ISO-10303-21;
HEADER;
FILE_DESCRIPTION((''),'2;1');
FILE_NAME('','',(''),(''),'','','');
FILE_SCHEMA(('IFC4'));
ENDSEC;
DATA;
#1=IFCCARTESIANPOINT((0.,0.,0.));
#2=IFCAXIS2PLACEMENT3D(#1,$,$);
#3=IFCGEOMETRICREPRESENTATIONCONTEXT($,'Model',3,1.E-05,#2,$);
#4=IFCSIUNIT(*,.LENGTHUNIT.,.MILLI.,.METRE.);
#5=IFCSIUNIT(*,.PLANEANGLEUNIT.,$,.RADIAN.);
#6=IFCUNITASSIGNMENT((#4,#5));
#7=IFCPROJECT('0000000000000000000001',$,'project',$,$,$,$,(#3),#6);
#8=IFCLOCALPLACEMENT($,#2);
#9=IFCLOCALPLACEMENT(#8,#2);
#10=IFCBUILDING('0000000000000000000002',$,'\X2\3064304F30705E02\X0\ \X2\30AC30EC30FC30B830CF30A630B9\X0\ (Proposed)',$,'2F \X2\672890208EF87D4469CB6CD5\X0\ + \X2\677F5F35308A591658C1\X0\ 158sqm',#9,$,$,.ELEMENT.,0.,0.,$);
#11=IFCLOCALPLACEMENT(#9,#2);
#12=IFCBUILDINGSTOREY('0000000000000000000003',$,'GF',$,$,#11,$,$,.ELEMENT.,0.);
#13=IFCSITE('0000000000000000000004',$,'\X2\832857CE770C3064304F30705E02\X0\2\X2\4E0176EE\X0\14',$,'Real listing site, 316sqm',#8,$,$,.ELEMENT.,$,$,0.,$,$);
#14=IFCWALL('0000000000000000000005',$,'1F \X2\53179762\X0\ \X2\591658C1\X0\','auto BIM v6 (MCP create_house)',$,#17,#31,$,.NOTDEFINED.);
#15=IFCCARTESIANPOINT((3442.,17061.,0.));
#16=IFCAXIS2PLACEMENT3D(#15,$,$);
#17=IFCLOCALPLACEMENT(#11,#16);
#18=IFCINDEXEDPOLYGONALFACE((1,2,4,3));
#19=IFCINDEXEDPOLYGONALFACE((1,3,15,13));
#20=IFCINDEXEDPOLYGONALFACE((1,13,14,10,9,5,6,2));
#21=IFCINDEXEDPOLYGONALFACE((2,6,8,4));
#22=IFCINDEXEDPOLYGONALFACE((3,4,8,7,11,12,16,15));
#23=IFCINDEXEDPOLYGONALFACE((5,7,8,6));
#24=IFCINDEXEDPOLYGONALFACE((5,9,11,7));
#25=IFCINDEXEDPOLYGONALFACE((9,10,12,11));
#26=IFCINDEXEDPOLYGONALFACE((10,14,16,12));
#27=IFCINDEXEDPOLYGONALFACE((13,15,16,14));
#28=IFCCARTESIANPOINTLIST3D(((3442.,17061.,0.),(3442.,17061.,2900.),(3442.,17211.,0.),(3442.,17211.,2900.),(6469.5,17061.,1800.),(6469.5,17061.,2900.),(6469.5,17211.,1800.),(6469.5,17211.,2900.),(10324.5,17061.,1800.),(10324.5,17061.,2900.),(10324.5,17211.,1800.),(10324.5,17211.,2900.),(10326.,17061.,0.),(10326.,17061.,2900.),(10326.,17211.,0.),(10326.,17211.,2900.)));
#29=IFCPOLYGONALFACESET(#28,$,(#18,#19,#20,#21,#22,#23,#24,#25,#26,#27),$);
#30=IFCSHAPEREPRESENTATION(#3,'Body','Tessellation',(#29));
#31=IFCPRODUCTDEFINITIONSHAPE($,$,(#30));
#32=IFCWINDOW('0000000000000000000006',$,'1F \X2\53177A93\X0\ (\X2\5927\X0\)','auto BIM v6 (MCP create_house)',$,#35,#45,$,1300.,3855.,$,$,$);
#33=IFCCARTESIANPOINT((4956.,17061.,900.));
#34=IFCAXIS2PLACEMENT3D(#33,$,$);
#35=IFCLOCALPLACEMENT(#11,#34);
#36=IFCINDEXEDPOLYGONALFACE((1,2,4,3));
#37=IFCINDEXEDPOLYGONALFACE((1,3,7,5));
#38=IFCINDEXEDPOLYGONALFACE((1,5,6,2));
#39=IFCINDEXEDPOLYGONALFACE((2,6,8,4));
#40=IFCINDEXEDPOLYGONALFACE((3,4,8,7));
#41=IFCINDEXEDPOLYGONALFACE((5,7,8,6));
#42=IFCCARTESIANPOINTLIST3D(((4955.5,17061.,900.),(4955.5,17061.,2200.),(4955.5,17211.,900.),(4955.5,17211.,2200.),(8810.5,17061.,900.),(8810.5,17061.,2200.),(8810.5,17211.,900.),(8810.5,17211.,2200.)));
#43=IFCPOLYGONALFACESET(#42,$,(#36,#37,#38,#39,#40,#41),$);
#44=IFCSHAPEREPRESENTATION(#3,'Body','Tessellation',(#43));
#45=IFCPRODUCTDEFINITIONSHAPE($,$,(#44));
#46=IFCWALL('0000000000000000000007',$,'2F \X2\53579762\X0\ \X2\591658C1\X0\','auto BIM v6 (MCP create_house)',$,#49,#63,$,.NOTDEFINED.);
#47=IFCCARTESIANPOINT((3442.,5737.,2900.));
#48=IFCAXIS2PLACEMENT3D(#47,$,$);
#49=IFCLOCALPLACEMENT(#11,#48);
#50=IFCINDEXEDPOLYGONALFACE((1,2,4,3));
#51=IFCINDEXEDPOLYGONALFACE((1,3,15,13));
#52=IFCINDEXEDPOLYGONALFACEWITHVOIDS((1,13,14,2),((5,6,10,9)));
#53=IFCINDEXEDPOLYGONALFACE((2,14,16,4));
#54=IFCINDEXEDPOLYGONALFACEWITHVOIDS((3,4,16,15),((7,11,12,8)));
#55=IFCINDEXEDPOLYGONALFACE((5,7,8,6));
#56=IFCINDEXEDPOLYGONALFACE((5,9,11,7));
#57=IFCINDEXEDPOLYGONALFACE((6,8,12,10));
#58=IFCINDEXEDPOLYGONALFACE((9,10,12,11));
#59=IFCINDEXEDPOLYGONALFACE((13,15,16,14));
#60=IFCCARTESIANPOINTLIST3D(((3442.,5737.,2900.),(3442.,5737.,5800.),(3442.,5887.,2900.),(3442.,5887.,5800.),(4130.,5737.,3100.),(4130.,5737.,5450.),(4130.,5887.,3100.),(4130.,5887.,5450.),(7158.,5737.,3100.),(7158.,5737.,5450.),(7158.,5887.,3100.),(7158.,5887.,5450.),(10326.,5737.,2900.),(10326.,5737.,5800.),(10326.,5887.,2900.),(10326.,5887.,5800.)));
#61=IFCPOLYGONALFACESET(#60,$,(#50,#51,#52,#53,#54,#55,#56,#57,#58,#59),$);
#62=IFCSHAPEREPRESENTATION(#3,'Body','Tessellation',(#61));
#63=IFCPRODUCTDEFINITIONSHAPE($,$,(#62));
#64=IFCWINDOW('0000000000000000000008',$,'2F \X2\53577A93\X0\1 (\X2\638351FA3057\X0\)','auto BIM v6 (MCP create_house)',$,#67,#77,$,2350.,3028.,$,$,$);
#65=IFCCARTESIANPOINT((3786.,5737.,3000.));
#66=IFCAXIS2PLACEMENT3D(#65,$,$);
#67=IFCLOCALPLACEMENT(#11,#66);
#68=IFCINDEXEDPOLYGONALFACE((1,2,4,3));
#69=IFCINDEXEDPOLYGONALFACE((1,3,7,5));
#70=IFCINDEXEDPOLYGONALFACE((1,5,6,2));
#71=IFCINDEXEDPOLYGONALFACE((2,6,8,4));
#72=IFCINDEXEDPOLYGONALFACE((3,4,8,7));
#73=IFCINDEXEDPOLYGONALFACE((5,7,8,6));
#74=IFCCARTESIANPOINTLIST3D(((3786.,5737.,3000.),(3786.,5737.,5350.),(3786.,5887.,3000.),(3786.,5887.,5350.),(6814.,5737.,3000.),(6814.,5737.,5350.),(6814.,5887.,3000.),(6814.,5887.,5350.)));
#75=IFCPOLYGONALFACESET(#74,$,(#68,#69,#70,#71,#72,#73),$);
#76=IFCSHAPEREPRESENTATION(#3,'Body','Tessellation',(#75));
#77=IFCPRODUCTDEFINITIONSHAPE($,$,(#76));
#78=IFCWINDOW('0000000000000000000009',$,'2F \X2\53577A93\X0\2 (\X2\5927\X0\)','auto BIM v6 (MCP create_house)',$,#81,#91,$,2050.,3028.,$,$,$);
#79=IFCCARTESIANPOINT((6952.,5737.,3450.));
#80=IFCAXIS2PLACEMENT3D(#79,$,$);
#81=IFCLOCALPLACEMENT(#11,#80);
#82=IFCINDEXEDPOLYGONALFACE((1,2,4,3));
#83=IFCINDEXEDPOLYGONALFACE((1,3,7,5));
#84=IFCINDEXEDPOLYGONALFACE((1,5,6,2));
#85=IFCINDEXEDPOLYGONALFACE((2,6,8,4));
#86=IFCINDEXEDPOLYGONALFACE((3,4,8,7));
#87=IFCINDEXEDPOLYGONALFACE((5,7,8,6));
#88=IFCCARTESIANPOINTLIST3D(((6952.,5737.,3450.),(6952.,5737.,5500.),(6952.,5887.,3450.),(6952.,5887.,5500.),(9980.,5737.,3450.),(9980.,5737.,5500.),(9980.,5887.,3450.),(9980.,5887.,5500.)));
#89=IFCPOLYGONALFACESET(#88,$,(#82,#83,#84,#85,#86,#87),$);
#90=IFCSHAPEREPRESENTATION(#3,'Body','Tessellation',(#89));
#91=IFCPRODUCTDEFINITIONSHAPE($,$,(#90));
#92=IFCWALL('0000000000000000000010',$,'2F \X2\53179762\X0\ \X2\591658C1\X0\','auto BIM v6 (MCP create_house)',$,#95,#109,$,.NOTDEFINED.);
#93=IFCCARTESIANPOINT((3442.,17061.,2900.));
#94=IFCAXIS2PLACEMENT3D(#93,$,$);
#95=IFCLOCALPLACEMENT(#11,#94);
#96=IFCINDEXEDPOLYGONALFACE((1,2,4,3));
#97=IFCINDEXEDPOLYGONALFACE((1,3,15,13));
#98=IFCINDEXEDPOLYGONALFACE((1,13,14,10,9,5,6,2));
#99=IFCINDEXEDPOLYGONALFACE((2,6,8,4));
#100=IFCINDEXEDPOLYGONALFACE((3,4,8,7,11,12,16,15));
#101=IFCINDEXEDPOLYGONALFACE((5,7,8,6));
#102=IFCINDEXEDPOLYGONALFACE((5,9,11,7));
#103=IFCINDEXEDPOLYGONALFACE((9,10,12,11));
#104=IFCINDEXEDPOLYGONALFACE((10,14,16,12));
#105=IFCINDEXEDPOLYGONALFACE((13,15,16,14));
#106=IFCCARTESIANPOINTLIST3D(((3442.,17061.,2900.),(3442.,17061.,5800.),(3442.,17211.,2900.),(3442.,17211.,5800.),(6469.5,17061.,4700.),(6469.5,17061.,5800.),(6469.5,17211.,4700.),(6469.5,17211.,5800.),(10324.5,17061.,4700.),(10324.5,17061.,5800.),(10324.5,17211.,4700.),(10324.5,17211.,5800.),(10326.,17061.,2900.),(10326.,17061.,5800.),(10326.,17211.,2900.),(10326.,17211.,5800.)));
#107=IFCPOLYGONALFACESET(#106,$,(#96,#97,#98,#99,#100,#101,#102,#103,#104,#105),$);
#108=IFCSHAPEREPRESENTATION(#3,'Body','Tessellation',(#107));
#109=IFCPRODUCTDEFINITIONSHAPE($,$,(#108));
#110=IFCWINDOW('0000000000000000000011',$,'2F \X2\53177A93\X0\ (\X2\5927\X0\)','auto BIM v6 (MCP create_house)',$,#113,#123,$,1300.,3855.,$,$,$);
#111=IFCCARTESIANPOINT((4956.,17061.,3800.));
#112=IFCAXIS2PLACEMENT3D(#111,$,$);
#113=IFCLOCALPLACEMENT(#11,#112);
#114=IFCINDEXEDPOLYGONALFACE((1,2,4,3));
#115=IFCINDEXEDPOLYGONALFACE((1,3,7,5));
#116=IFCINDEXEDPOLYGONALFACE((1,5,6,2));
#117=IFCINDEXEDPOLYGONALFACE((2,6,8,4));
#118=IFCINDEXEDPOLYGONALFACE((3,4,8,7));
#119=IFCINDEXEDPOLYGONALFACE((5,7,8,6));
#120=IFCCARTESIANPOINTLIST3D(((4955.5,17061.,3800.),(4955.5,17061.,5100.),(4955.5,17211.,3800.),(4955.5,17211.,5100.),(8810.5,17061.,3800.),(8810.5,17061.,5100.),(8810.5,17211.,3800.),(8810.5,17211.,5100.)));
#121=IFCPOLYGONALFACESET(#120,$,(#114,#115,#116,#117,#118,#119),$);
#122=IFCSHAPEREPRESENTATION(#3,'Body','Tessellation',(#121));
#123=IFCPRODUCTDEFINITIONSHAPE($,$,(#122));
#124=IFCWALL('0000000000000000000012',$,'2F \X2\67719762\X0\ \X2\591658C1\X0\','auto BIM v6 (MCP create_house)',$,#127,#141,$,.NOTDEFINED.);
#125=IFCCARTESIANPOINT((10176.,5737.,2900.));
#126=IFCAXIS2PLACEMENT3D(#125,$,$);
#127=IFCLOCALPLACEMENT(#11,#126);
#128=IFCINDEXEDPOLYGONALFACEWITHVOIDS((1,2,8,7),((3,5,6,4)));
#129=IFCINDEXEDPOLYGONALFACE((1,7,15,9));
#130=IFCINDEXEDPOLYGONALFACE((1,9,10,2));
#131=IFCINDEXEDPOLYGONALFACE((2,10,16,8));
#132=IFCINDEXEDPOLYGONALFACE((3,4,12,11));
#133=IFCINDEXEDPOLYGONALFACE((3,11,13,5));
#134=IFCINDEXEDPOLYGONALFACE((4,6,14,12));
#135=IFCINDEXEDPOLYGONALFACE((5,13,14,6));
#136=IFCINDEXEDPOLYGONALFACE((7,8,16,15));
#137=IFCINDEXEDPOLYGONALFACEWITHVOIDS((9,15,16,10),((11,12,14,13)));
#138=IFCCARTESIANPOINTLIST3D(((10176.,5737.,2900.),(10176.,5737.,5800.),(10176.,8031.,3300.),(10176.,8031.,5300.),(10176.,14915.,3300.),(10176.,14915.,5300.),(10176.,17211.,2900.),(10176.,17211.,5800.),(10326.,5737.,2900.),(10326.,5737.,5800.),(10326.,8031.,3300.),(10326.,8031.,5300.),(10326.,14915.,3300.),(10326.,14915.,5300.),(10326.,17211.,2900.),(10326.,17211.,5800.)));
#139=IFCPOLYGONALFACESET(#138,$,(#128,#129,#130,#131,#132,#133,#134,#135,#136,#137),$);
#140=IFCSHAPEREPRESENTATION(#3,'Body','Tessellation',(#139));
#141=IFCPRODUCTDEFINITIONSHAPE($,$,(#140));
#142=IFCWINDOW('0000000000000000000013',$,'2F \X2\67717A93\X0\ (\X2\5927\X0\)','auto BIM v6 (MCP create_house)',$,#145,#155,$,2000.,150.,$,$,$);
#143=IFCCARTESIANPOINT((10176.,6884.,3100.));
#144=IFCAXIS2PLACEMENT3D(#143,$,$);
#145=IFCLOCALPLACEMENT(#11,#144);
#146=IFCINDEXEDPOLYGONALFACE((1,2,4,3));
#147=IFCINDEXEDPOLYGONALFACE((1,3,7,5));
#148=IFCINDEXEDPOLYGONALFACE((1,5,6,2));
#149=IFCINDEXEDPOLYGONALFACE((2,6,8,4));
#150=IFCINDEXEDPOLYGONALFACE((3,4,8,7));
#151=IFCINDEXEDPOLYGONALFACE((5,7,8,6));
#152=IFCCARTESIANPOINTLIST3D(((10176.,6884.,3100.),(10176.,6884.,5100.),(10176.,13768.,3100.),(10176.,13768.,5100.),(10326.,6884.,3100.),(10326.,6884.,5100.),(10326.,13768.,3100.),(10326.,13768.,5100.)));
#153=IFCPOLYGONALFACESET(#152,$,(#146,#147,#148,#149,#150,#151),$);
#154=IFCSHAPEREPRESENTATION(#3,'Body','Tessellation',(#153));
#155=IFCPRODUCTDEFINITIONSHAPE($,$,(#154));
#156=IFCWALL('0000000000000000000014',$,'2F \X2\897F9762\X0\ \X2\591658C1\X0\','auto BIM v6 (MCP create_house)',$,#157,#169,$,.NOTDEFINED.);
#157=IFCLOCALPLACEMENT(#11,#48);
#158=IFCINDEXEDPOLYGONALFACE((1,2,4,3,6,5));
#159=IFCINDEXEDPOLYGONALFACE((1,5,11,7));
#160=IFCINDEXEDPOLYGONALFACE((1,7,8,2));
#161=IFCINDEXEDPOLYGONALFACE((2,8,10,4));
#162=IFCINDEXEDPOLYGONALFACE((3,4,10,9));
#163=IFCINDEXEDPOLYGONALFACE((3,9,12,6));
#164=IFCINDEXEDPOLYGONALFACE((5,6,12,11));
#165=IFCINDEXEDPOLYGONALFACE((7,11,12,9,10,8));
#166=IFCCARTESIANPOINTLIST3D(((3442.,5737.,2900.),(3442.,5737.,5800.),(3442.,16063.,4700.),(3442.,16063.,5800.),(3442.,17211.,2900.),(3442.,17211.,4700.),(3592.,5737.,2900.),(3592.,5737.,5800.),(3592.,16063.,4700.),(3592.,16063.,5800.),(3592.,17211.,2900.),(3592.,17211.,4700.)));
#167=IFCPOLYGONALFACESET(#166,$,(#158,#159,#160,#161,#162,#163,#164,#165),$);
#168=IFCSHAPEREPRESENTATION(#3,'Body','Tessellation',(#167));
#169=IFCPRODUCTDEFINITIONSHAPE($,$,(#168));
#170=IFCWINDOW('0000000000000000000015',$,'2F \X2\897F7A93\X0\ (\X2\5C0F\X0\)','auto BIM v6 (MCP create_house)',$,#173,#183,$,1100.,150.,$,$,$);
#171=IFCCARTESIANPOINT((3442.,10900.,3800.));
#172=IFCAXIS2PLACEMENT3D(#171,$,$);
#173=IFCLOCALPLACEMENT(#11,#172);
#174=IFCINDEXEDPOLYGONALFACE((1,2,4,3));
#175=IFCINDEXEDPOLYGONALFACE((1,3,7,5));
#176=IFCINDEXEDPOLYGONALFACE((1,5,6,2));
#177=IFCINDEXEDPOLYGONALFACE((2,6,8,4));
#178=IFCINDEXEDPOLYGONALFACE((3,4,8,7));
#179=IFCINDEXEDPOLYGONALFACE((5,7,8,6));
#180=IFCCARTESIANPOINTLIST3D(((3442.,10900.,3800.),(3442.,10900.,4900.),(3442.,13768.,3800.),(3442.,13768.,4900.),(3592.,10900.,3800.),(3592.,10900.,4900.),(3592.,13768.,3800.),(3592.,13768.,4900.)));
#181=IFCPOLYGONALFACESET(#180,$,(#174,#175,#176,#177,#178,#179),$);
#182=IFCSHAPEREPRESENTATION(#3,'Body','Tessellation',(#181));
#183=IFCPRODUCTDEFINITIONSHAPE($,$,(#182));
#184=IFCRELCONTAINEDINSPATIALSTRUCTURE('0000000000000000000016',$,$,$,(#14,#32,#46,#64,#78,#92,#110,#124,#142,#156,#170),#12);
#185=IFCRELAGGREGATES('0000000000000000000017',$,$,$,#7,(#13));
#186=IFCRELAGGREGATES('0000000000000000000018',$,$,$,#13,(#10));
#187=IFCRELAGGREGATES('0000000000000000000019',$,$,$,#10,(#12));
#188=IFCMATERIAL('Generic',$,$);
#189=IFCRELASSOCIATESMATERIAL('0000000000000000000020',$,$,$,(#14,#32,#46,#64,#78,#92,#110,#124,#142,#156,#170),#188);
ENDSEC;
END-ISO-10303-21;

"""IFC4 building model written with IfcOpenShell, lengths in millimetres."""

from ifc_helpers import new_model, si_unit, frame, frame_2d, origin, place, context, project, spatial, rectangle, extrude, material, element, fill, save


model = new_model("IFC4")

# Units and contexts
model_context = context("Model", 3, precision=1e-05, world=origin())
ifc_project = project(units=[si_unit("LENGTHUNIT", "METRE", prefix="MILLI"), si_unit("PLANEANGLEUNIT", "RADIAN")], contexts=[model_context])

# Site, building, storey
site_placement = place(None, origin())
site = spatial("IfcSite", under=ifc_project, at=site_placement, Name="茨城県つくば市2丁目14", ObjectType="Real listing site, 316sqm", CompositionType="ELEMENT", RefElevation=0.0)
building_placement = place(site_placement, origin())
building = spatial("IfcBuilding", under=site, at=building_placement, Name="つくば市 ガレージハウス (Proposed)", ObjectType="2F 木造軸組構法 + 板張り外壁 158sqm", CompositionType="ELEMENT", ElevationOfRefHeight=0.0, ElevationOfTerrain=0.0)
storey_placement = place(building_placement, origin())
storey = spatial("IfcBuildingStorey", under=building, at=storey_placement, Name="GF", CompositionType="ELEMENT", Elevation=0.0)

# Wall, opening, window
ifc_material = material(Name="Generic")
wall_1_placement = place(storey_placement, frame((3442.0, 17061.0, 0.0)))
wall_1 = element("IfcWall", 1, at=wall_1_placement, inside=storey, material=ifc_material, Name="1F 北面 外壁", Description="auto BIM v6 (MCP create_house)", PredefinedType="NOTDEFINED", context=model_context, shape_type="SweptSolid", body=[
    extrude(rectangle(XDim=6884.0, YDim=150.0, at=frame_2d((3442.0, 75.0))), frame((3442.0, 17061.0, 0.0)), (0.0, 0.0, 1.0), 2900.0),
])
opening_1_placement = place(storey_placement, frame((4956.0, 17061.0, 900.0)))
opening_1 = element("IfcOpeningElement", 2, at=opening_1_placement, cuts=wall_1, PredefinedType="NOTDEFINED", context=model_context, shape_type="SweptSolid", body=[
    extrude(rectangle(XDim=3855.0, YDim=150.0, at=frame_2d((1927.0, 75.0))), frame((4956.0, 17061.0, 900.0)), (0.0, 0.0, 1.0), 1300.0),
])
window_1_placement = place(storey_placement, frame((4956.0, 17061.0, 900.0)))
window_1 = element("IfcWindow", 3, at=window_1_placement, inside=storey, material=ifc_material, Name="1F 北窓 (大)", Description="auto BIM v6 (MCP create_house)", OverallHeight=1300.0, OverallWidth=3855.0, context=model_context, shape_type="SweptSolid", body=[
    extrude(rectangle(XDim=3855.0, YDim=150.0, at=frame_2d((1927.0, 75.0))), frame((4956.0, 17061.0, 900.0)), (0.0, 0.0, 1.0), 1300.0),
])
fill(opening_1, window_1)

# Wall, openings, windows
wall_2_placement = place(storey_placement, frame((3442.0, 5737.0, 2900.0)))
wall_2 = element("IfcWall", 4, at=wall_2_placement, inside=storey, material=ifc_material, Name="2F 南面 外壁", Description="auto BIM v6 (MCP create_house)", PredefinedType="NOTDEFINED", context=model_context, shape_type="SweptSolid", body=[
    extrude(rectangle(XDim=6884.0, YDim=150.0, at=frame_2d((3442.0, 75.0))), frame((3442.0, 5737.0, 2900.0)), (0.0, 0.0, 1.0), 2900.0),
])
opening_2_placement = place(storey_placement, frame((3786.0, 5737.0, 3000.0)))
opening_2 = element("IfcOpeningElement", 5, at=opening_2_placement, cuts=wall_2, PredefinedType="NOTDEFINED", context=model_context, shape_type="SweptSolid", body=[
    extrude(rectangle(XDim=3028.0, YDim=150.0, at=frame_2d((1514.0, 75.0))), frame((3786.0, 5737.0, 3000.0)), (0.0, 0.0, 1.0), 2350.0),
])
opening_3_placement = place(storey_placement, frame((6952.0, 5737.0, 3450.0)))
opening_3 = element("IfcOpeningElement", 6, at=opening_3_placement, cuts=wall_2, PredefinedType="NOTDEFINED", context=model_context, shape_type="SweptSolid", body=[
    extrude(rectangle(XDim=3028.0, YDim=150.0, at=frame_2d((1514.0, 75.0))), frame((6952.0, 5737.0, 3450.0)), (0.0, 0.0, 1.0), 2050.0),
])
window_2_placement = place(storey_placement, frame((3786.0, 5737.0, 3000.0)))
window_2 = element("IfcWindow", 7, at=window_2_placement, inside=storey, material=ifc_material, Name="2F 南窓1 (掃出し)", Description="auto BIM v6 (MCP create_house)", OverallHeight=2350.0, OverallWidth=3028.0, context=model_context, shape_type="SweptSolid", body=[
    extrude(rectangle(XDim=3028.0, YDim=150.0, at=frame_2d((1514.0, 75.0))), frame((3786.0, 5737.0, 3000.0)), (0.0, 0.0, 1.0), 2350.0),
])
fill(opening_2, window_2)
window_3_placement = place(storey_placement, frame((6952.0, 5737.0, 3450.0)))
window_3 = element("IfcWindow", 8, at=window_3_placement, inside=storey, material=ifc_material, Name="2F 南窓2 (大)", Description="auto BIM v6 (MCP create_house)", OverallHeight=2050.0, OverallWidth=3028.0, context=model_context, shape_type="SweptSolid", body=[
    extrude(rectangle(XDim=3028.0, YDim=150.0, at=frame_2d((1514.0, 75.0))), frame((6952.0, 5737.0, 3450.0)), (0.0, 0.0, 1.0), 2050.0),
])
fill(opening_3, window_3)

# Walls, openings, windows
wall_3_placement = place(storey_placement, frame((3442.0, 17061.0, 2900.0)))
wall_3 = element("IfcWall", 9, at=wall_3_placement, inside=storey, material=ifc_material, Name="2F 北面 外壁", Description="auto BIM v6 (MCP create_house)", PredefinedType="NOTDEFINED", context=model_context, shape_type="SweptSolid", body=[
    extrude(rectangle(XDim=6884.0, YDim=150.0, at=frame_2d((3442.0, 75.0))), frame((3442.0, 17061.0, 2900.0)), (0.0, 0.0, 1.0), 2900.0),
])
opening_4_placement = place(storey_placement, frame((4956.0, 17061.0, 3800.0)))
opening_4 = element("IfcOpeningElement", 10, at=opening_4_placement, cuts=wall_3, PredefinedType="NOTDEFINED", context=model_context, shape_type="SweptSolid", body=[
    extrude(rectangle(XDim=3855.0, YDim=150.0, at=frame_2d((1927.0, 75.0))), frame((4956.0, 17061.0, 3800.0)), (0.0, 0.0, 1.0), 1300.0),
])
window_4_placement = place(storey_placement, frame((4956.0, 17061.0, 3800.0)))
window_4 = element("IfcWindow", 11, at=window_4_placement, inside=storey, material=ifc_material, Name="2F 北窓 (大)", Description="auto BIM v6 (MCP create_house)", OverallHeight=1300.0, OverallWidth=3855.0, context=model_context, shape_type="SweptSolid", body=[
    extrude(rectangle(XDim=3855.0, YDim=150.0, at=frame_2d((1927.0, 75.0))), frame((4956.0, 17061.0, 3800.0)), (0.0, 0.0, 1.0), 1300.0),
])
fill(opening_4, window_4)
wall_4_placement = place(storey_placement, frame((10176.0, 5737.0, 2900.0)))
wall_4 = element("IfcWall", 12, at=wall_4_placement, inside=storey, material=ifc_material, Name="2F 東面 外壁", Description="auto BIM v6 (MCP create_house)", PredefinedType="NOTDEFINED", context=model_context, shape_type="SweptSolid", body=[
    extrude(rectangle(XDim=150.0, YDim=11474.0, at=frame_2d((75.0, 5737.0))), frame((10176.0, 5737.0, 2900.0)), (0.0, 0.0, 1.0), 2900.0),
])
opening_5_placement = place(storey_placement, frame((10176.0, 6884.0, 3100.0)))
opening_5 = element("IfcOpeningElement", 13, at=opening_5_placement, cuts=wall_4, PredefinedType="NOTDEFINED", context=model_context, shape_type="SweptSolid", body=[
    extrude(rectangle(XDim=150.0, YDim=6884.0, at=frame_2d((75.0, 3442.0))), frame((10176.0, 6884.0, 3100.0)), (0.0, 0.0, 1.0), 2000.0),
])
window_5_placement = place(storey_placement, frame((10176.0, 6884.0, 3100.0)))
window_5 = element("IfcWindow", 14, at=window_5_placement, inside=storey, material=ifc_material, Name="2F 東窓 (大)", Description="auto BIM v6 (MCP create_house)", OverallHeight=2000.0, OverallWidth=150.0, context=model_context, shape_type="SweptSolid", body=[
    extrude(rectangle(XDim=150.0, YDim=6884.0, at=frame_2d((75.0, 3442.0))), frame((10176.0, 6884.0, 3100.0)), (0.0, 0.0, 1.0), 2000.0),
])
fill(opening_5, window_5)
wall_5_placement = place(storey_placement, frame((3442.0, 5737.0, 2900.0)))
wall_5 = element("IfcWall", 15, at=wall_5_placement, inside=storey, material=ifc_material, Name="2F 西面 外壁", Description="auto BIM v6 (MCP create_house)", PredefinedType="NOTDEFINED", context=model_context, shape_type="SweptSolid", body=[
    extrude(rectangle(XDim=150.0, YDim=11474.0, at=frame_2d((75.0, 5737.0))), frame((3442.0, 5737.0, 2900.0)), (0.0, 0.0, 1.0), 2900.0),
])
opening_6_placement = place(storey_placement, frame((3442.0, 10900.0, 3800.0)))
opening_6 = element("IfcOpeningElement", 16, at=opening_6_placement, cuts=wall_5, PredefinedType="NOTDEFINED", context=model_context, shape_type="SweptSolid", body=[
    extrude(rectangle(XDim=150.0, YDim=2868.0, at=frame_2d((75.0, 1434.0))), frame((3442.0, 10900.0, 3800.0)), (0.0, 0.0, 1.0), 1100.0),
])
window_6_placement = place(storey_placement, frame((3442.0, 10900.0, 3800.0)))
window_6 = element("IfcWindow", 17, at=window_6_placement, inside=storey, material=ifc_material, Name="2F 西窓 (小)", Description="auto BIM v6 (MCP create_house)", OverallHeight=1100.0, OverallWidth=150.0, context=model_context, shape_type="SweptSolid", body=[
    extrude(rectangle(XDim=150.0, YDim=2868.0, at=frame_2d((75.0, 1434.0))), frame((3442.0, 10900.0, 3800.0)), (0.0, 0.0, 1.0), 1100.0),
])
fill(opening_6, window_6)

save(model, "model.ifc")
